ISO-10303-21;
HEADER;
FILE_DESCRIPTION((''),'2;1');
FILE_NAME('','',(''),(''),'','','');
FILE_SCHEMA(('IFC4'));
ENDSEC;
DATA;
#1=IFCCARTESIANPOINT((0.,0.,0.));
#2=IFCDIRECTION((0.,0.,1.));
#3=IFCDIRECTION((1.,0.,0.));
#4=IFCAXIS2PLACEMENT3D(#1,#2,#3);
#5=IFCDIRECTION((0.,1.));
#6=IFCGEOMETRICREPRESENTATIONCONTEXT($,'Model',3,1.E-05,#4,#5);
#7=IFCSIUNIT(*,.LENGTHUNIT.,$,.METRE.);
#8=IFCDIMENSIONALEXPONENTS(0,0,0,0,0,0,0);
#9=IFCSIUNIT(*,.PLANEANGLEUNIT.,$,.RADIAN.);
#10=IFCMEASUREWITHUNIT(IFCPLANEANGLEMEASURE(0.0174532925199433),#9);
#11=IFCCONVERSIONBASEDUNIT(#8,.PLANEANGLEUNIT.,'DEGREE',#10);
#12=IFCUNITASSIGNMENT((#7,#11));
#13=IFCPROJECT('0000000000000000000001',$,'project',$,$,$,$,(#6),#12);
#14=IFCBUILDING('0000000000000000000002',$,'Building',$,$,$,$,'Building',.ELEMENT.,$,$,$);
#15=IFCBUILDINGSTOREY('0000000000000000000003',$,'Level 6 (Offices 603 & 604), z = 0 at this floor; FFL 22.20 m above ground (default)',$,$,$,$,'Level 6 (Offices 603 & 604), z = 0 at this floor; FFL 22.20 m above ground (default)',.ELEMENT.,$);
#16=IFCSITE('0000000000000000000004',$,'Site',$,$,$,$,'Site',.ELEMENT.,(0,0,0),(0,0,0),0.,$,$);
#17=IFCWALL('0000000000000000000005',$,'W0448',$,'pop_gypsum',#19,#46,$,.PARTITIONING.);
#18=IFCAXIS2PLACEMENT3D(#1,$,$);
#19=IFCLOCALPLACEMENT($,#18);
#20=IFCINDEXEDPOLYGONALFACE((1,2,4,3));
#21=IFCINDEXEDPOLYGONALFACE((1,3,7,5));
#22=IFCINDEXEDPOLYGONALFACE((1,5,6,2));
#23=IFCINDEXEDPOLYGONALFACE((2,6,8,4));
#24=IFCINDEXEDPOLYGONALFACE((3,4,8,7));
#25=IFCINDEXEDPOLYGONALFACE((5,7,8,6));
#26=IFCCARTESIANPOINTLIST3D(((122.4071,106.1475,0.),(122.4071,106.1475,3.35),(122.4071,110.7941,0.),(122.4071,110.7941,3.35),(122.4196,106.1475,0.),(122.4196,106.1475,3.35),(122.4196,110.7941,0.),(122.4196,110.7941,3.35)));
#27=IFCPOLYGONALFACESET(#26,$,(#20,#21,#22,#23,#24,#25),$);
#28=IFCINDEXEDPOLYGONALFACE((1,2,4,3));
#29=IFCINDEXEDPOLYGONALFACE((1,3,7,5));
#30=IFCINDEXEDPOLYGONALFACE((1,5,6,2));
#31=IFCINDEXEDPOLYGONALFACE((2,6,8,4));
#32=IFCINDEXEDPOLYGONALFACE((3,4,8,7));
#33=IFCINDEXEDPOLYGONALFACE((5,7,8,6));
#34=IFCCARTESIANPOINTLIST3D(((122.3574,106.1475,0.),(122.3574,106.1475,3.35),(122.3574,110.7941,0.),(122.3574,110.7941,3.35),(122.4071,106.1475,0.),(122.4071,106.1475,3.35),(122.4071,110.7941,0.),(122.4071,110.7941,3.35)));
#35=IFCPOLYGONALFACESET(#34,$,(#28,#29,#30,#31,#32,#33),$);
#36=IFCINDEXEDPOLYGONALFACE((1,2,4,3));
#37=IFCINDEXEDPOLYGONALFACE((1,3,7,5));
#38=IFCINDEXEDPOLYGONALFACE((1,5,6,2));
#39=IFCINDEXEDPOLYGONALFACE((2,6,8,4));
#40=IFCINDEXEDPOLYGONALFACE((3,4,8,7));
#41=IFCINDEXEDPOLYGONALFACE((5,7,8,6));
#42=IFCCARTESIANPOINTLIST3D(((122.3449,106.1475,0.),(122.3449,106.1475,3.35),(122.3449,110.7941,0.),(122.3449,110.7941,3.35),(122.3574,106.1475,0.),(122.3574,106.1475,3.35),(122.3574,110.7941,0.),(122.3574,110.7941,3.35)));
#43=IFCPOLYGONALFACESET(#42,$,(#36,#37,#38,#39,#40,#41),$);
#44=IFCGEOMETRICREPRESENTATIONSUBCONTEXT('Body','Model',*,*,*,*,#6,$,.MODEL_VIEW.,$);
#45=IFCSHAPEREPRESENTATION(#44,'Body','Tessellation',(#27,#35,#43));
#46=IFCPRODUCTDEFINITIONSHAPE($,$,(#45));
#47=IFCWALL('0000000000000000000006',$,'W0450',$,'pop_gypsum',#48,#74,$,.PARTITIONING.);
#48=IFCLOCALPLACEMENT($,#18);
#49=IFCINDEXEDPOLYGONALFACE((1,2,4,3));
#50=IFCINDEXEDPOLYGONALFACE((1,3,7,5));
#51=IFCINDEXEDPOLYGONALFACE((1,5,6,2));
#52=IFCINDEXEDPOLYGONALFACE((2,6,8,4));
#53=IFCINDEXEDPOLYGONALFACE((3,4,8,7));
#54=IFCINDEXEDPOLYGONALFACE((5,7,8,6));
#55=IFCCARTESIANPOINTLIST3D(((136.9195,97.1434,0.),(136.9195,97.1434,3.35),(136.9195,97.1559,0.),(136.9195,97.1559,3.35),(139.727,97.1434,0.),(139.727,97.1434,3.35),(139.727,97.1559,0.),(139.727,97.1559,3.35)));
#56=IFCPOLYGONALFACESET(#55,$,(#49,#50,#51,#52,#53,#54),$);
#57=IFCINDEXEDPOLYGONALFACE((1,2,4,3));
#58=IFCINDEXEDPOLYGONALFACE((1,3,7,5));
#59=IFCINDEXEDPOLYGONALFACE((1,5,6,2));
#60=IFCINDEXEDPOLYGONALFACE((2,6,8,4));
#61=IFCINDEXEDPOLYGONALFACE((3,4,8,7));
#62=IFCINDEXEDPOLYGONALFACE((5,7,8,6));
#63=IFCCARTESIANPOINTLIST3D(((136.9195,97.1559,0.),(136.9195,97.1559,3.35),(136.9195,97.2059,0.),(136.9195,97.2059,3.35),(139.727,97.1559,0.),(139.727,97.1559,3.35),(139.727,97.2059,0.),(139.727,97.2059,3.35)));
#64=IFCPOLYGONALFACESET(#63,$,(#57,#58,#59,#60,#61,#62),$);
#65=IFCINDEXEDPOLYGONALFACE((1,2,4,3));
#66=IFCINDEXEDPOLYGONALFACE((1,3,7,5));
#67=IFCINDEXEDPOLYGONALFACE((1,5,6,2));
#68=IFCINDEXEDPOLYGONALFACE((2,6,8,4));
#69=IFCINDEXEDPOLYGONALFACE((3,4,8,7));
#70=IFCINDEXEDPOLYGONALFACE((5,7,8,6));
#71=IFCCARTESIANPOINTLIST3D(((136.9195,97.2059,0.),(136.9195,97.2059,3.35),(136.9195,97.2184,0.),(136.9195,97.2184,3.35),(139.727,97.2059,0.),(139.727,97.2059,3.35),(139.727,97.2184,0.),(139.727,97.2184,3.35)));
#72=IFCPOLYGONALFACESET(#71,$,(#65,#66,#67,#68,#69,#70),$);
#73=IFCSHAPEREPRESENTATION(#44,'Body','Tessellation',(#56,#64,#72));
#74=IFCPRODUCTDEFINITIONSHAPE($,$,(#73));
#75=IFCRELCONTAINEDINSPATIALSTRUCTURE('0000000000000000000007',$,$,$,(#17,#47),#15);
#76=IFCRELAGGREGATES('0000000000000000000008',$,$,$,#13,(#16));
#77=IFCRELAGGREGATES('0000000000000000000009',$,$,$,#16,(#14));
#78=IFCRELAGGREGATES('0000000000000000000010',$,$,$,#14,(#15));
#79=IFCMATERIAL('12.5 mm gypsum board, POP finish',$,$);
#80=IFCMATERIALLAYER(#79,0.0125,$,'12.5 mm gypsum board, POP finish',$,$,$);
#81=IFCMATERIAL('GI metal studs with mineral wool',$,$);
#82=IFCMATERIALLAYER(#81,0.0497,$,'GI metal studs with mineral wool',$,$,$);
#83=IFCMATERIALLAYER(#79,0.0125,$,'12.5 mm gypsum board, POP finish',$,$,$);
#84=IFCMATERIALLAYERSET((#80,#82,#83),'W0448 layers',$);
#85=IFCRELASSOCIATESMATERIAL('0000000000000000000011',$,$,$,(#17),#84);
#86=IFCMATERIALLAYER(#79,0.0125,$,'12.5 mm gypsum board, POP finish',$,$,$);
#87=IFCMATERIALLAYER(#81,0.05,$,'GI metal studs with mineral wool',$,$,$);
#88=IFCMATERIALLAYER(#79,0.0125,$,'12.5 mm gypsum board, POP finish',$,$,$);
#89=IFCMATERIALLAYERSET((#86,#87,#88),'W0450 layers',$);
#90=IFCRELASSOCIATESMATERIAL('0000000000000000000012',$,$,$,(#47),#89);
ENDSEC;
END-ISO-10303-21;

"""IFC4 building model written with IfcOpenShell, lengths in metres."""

from ifc_helpers import new_model, entity, si_unit, converted_unit, direction, frame, frame_2d, origin_with_axes, place, context, subcontext, project, spatial, rectangle, extrude, material, layer, layer_set, layer_usage, element, save


model = new_model("IFC4")

# Units and contexts
model_context = context("Model", 3, precision=1e-05, world=origin_with_axes(), true_north=direction((0.0, 1.0)))
body_context = subcontext(model_context, "Body", "Model", "MODEL_VIEW")
ifc_project = project(units=[si_unit("LENGTHUNIT", "METRE"), converted_unit("PLANEANGLEUNIT", "DEGREE", entity("IfcPlaneAngleMeasure", 0.0174532925199433), si_unit("PLANEANGLEUNIT", "RADIAN"), dimensions=[0, 0, 0, 0, 0, 0, 0])], contexts=[model_context])

# Site, building, storey
site = spatial("IfcSite", under=ifc_project, Name="Site", LongName="Site", CompositionType="ELEMENT", RefLatitude=(0, 0, 0), RefLongitude=(0, 0, 0), RefElevation=0.0)
building = spatial("IfcBuilding", under=site, Name="Building", LongName="Building", CompositionType="ELEMENT")
storey = spatial("IfcBuildingStorey", under=building, Name="Level 6 (Offices 603 & 604), z = 0 at this floor; FFL 22.20 m above ground (default)", LongName="Level 6 (Offices 603 & 604), z = 0 at this floor; FFL 22.20 m above ground (default)", CompositionType="ELEMENT")

# Shared definitions
placement = place(None, origin_with_axes())

# Shared definitions
ifc_material_1 = material(Name="12.5 mm gypsum board, POP finish")
ifc_material_2 = material(Name="GI metal studs with mineral wool")

# Walls
ifc_layer_1 = layer(ifc_material_1, 0.0125, Name="12.5 mm gypsum board, POP finish")
ifc_layer_2 = layer(ifc_material_2, 0.0497, Name="GI metal studs with mineral wool")
ifc_layer_3 = layer(ifc_material_1, 0.0125, Name="12.5 mm gypsum board, POP finish")
ifc_layer_set_1 = layer_set([ifc_layer_1, ifc_layer_2, ifc_layer_3], Name="W0448 layers")
ifc_layer_usage_1 = layer_usage(ifc_layer_set_1, "AXIS2", "POSITIVE", -0.0374)
element("IfcWall", 1, at=placement, inside=storey, material=ifc_layer_usage_1, Name="W0448", ObjectType="pop_gypsum", PredefinedType="PARTITIONING", context=body_context, shape_type="SweptSolid", body=[
    extrude(rectangle(XDim=4.6466, YDim=0.0125, at=frame_2d((0.0, 0.0), x_axis=(0.0, 1.0))), frame((122.4134, 108.4708, 0.0), z_axis=(0.0, 0.0, 1.0), x_axis=(1.0, 0.0, 0.0)), (0.0, 0.0, 1.0), 3.35),
    extrude(rectangle(XDim=4.6466, YDim=0.0497, at=frame_2d((-0.0311, 0.0), x_axis=(0.0, 1.0))), frame((122.4134, 108.4708, 0.0), z_axis=(0.0, 0.0, 1.0), x_axis=(1.0, 0.0, 0.0)), (0.0, 0.0, 1.0), 3.35),
    extrude(rectangle(XDim=4.6466, YDim=0.0125, at=frame_2d((-0.0622, 0.0), x_axis=(0.0, 1.0))), frame((122.4134, 108.4708, 0.0), z_axis=(0.0, 0.0, 1.0), x_axis=(1.0, 0.0, 0.0)), (0.0, 0.0, 1.0), 3.35),
])
ifc_layer_4 = layer(ifc_material_1, 0.0125, Name="12.5 mm gypsum board, POP finish")
ifc_layer_5 = layer(ifc_material_2, 0.05, Name="GI metal studs with mineral wool")
ifc_layer_6 = layer(ifc_material_1, 0.0125, Name="12.5 mm gypsum board, POP finish")
ifc_layer_set_2 = layer_set([ifc_layer_4, ifc_layer_5, ifc_layer_6], Name="W0450 layers")
ifc_layer_usage_2 = layer_usage(ifc_layer_set_2, "AXIS2", "POSITIVE", -0.0375)
element("IfcWall", 2, at=placement, inside=storey, material=ifc_layer_usage_2, Name="W0450", ObjectType="pop_gypsum", PredefinedType="PARTITIONING", context=body_context, shape_type="SweptSolid", body=[
    extrude(rectangle(XDim=2.8075, YDim=0.0125, at=frame_2d((0.0, 0.0), x_axis=(1.0, 0.0))), frame((138.3233, 97.1496, 0.0), z_axis=(0.0, 0.0, 1.0), x_axis=(1.0, 0.0, 0.0)), (0.0, 0.0, 1.0), 3.35),
    extrude(rectangle(XDim=2.8075, YDim=0.05, at=frame_2d((0.0, 0.0312), x_axis=(1.0, 0.0))), frame((138.3233, 97.1496, 0.0), z_axis=(0.0, 0.0, 1.0), x_axis=(1.0, 0.0, 0.0)), (0.0, 0.0, 1.0), 3.35),
    extrude(rectangle(XDim=2.8075, YDim=0.0125, at=frame_2d((0.0, 0.0625), x_axis=(1.0, 0.0))), frame((138.3233, 97.1496, 0.0), z_axis=(0.0, 0.0, 1.0), x_axis=(1.0, 0.0, 0.0)), (0.0, 0.0, 1.0), 3.35),
])

save(model, "model.ifc")
